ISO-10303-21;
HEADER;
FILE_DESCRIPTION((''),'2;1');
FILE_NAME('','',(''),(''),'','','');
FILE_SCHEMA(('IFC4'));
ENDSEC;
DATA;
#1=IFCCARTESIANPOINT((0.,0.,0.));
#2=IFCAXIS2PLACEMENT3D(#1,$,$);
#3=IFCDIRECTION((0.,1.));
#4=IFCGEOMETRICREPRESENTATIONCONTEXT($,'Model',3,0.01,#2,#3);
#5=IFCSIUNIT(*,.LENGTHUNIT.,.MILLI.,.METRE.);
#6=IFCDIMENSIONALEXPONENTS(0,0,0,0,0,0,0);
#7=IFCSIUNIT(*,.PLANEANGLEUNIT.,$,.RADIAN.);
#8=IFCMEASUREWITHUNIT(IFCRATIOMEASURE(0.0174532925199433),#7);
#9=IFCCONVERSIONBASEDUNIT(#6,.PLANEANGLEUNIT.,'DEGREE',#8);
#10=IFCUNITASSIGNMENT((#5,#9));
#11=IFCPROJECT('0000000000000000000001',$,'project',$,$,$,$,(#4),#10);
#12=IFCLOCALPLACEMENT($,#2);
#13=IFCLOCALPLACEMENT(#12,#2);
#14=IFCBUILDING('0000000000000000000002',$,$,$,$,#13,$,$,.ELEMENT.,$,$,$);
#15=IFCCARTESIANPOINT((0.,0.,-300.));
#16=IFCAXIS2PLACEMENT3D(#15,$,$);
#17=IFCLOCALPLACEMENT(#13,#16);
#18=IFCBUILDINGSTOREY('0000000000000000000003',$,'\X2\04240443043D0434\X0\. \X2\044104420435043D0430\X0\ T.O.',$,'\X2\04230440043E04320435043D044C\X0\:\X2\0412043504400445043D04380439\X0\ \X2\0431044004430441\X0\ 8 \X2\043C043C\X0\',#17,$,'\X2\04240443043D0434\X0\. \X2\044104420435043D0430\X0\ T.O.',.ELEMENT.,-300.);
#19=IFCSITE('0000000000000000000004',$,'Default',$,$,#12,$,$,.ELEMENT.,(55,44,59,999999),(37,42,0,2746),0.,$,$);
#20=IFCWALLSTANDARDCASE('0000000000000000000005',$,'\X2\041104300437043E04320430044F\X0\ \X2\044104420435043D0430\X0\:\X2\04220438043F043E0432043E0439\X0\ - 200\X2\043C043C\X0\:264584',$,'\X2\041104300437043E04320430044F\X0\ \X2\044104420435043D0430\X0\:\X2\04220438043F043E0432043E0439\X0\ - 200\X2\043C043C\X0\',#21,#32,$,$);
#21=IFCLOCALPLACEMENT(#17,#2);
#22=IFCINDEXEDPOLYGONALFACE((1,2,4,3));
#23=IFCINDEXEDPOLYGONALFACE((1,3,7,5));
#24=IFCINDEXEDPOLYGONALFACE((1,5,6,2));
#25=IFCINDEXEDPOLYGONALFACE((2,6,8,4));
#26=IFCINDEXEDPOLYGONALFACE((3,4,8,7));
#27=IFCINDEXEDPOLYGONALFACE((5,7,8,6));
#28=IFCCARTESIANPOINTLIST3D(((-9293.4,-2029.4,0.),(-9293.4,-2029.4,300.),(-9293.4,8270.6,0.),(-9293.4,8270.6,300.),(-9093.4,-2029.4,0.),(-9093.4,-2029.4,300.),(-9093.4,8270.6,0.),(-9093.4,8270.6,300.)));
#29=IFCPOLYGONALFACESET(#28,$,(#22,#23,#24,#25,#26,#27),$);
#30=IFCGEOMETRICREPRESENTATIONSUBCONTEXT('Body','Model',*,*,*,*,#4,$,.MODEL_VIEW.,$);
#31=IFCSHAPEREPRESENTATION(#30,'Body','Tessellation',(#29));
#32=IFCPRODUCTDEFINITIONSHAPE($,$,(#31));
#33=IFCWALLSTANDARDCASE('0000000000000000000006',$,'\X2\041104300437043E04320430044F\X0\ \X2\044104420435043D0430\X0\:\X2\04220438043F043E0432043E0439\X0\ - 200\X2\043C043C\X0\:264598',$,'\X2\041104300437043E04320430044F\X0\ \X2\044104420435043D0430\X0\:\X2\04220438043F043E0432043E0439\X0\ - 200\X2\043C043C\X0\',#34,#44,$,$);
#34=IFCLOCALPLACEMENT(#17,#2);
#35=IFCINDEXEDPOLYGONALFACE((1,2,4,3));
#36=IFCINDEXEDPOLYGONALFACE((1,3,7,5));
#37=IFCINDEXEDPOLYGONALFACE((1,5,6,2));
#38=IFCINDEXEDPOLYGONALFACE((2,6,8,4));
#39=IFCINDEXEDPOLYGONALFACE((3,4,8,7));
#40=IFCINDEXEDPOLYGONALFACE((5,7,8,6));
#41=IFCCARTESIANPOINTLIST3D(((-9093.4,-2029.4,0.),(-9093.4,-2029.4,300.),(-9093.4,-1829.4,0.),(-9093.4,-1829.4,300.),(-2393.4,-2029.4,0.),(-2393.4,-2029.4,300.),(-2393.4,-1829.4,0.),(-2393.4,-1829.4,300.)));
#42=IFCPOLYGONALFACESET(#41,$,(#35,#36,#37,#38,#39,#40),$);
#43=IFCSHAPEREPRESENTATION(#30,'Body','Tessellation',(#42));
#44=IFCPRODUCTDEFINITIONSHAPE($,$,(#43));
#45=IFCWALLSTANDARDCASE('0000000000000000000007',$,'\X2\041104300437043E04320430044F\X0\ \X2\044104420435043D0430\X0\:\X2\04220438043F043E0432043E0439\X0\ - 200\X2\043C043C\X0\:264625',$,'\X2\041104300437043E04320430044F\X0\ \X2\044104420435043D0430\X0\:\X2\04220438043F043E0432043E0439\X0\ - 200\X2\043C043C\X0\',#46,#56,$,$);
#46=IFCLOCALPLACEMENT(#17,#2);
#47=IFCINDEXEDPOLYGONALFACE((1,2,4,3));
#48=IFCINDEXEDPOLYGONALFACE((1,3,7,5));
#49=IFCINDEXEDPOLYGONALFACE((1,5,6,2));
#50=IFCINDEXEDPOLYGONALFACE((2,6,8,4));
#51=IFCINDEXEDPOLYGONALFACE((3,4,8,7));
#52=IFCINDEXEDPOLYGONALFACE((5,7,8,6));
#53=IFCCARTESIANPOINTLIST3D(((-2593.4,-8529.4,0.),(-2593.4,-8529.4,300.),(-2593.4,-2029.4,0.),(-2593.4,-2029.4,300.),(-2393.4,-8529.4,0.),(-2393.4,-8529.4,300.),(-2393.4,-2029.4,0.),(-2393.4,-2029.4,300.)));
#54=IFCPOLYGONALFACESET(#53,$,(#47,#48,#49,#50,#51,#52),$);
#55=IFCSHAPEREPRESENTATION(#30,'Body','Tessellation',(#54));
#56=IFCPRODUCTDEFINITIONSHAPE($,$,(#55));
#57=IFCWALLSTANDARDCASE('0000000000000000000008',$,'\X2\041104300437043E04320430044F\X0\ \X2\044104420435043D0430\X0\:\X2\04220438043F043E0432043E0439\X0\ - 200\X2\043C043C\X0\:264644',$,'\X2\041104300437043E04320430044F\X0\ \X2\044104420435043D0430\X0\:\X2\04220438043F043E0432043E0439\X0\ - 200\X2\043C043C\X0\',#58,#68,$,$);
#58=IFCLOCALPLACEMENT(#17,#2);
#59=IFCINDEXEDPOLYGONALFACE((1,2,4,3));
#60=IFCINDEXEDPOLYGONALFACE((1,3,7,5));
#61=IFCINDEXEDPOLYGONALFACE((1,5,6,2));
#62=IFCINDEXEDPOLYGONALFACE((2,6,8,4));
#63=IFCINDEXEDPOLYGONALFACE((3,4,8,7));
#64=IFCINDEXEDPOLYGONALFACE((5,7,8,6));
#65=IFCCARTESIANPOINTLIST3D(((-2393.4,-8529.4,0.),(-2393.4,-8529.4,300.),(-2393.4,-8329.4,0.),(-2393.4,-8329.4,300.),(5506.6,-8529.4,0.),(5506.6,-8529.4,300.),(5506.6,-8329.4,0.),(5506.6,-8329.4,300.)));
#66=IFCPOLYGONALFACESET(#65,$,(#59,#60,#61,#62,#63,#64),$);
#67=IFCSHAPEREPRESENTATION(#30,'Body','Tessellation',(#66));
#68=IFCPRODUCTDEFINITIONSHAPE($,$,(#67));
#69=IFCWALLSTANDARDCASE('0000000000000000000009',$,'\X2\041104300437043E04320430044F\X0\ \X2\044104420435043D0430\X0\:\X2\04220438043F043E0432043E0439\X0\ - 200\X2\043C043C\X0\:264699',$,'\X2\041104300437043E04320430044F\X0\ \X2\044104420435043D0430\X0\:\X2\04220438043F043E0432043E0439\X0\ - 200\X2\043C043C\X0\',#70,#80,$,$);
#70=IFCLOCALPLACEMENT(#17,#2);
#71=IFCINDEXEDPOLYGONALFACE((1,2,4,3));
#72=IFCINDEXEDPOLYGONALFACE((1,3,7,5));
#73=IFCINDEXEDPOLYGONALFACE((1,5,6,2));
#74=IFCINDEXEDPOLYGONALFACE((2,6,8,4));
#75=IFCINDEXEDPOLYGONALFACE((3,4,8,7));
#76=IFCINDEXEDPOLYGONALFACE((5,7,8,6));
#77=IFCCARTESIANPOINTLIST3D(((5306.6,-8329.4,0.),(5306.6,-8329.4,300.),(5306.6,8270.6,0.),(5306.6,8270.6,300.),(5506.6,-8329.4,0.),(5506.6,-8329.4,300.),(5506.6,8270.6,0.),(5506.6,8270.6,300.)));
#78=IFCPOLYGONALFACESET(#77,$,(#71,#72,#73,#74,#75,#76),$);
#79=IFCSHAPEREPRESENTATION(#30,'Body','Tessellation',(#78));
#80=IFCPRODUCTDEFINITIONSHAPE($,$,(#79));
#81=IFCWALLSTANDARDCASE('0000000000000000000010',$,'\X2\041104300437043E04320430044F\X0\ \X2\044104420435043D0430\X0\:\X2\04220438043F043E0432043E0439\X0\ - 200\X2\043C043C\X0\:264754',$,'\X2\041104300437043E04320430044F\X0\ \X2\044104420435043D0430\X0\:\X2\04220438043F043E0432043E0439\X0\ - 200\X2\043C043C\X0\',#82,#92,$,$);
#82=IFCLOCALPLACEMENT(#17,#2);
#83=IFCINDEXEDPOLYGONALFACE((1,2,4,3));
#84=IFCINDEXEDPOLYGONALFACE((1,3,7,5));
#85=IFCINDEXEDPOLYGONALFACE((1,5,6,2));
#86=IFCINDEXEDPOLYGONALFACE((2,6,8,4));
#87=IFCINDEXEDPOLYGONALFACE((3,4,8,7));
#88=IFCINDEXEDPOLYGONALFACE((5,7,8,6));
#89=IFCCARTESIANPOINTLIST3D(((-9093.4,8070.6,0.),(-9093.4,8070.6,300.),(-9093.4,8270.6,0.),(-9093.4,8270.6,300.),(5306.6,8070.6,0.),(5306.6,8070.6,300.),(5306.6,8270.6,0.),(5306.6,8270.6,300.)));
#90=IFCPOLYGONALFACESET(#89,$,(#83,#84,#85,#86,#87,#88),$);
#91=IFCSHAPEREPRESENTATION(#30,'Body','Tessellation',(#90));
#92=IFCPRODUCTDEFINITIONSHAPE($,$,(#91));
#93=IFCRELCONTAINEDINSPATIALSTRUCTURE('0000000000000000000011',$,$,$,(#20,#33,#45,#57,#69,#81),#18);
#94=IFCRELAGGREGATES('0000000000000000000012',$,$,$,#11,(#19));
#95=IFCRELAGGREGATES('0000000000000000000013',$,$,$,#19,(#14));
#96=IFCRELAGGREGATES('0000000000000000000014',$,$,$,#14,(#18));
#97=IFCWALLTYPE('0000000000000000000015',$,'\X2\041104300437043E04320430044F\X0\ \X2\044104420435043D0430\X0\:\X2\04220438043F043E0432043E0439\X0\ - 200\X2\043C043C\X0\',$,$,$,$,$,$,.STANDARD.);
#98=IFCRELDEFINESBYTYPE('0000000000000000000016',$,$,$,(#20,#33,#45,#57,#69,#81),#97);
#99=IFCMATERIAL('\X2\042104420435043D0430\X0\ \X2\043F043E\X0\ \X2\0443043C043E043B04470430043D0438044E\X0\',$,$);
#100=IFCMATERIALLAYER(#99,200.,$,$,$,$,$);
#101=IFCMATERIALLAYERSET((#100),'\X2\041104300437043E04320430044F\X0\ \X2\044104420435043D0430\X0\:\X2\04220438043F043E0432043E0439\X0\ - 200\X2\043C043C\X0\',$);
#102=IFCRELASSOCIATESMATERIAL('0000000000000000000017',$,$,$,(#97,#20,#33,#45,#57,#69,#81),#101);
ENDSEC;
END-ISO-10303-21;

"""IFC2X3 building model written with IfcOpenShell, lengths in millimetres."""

from ifc_helpers import new_model, entity, si_unit, converted_unit, direction, frame, frame_2d, origin, place, context, subcontext, project, spatial, rectangle, extrude, clip, halfspace, material, layer, layer_set, layer_usage, type_object, element, save


model = new_model("IFC2X3")

# Units and contexts
model_context = context("Model", 3, precision=0.01, world=origin(), true_north=direction((0.0, 1.0)))
body_context = subcontext(model_context, "Body", "Model", "MODEL_VIEW")
ifc_project = project(units=[si_unit("LENGTHUNIT", "METRE", prefix="MILLI"), converted_unit("PLANEANGLEUNIT", "DEGREE", entity("IfcRatioMeasure", 0.0174532925199433), si_unit("PLANEANGLEUNIT", "RADIAN"), dimensions=[0, 0, 0, 0, 0, 0, 0])], contexts=[model_context])

# Site, building, storey
site_placement = place(None, origin())
site = spatial("IfcSite", under=ifc_project, at=site_placement, Name="Default", CompositionType="ELEMENT", RefLatitude=(55, 44, 59, 999999), RefLongitude=(37, 42, 0, 2746), RefElevation=0.0)
building_placement = place(site_placement, origin())
building = spatial("IfcBuilding", under=site, at=building_placement, CompositionType="ELEMENT")
storey_placement = place(building_placement, frame((0.0, 0.0, -300.0)))
storey = spatial("IfcBuildingStorey", under=building, at=storey_placement, Name="Фунд. стена T.O.", ObjectType="Уровень:Верхний брус 8 мм", LongName="Фунд. стена T.O.", CompositionType="ELEMENT", Elevation=-300.0)

# Walls
ifc_material = material(Name="Стена по умолчанию")
ifc_layer = layer(ifc_material, 200.0)
ifc_layer_set = layer_set([ifc_layer], Name="Базовая стена:Типовой - 200мм")
ifc_layer_usage_1 = layer_usage(ifc_layer_set, "AXIS2", "NEGATIVE", 100.0)
wall_type = type_object("IfcWallType", Name="Базовая стена:Типовой - 200мм", PredefinedType="STANDARD", material=ifc_layer_set)
wall_1_placement = place(storey_placement, frame((-9193.4, 8270.6, 0.0), z_axis=(0.0, 0.0, 1.0), x_axis=(0.0, -1.0, 0.0)))
element("IfcWallStandardCase", 1, at=wall_1_placement, inside=storey, type_object=wall_type, material=ifc_layer_usage_1, Name="Базовая стена:Типовой - 200мм:264584", ObjectType="Базовая стена:Типовой - 200мм", context=body_context, shape_type="Clipping", body=[
    clip(extrude(rectangle(XDim=10300.0, YDim=200.0, at=frame_2d((5150.0, 0.0), x_axis=(-1.0, 0.0))), origin(), (0.0, 0.0, 1.0), 300.0), halfspace(frame((0.0, 0.0, -4300.0)), True)),
])
ifc_layer_usage_2 = layer_usage(ifc_layer_set, "AXIS2", "NEGATIVE", 100.0)
wall_2_placement = place(storey_placement, frame((-9093.4, -1929.4, 0.0)))
element("IfcWallStandardCase", 2, at=wall_2_placement, inside=storey, type_object=wall_type, material=ifc_layer_usage_2, Name="Базовая стена:Типовой - 200мм:264598", ObjectType="Базовая стена:Типовой - 200мм", context=body_context, shape_type="Clipping", body=[
    clip(extrude(rectangle(XDim=6700.0, YDim=200.0, at=frame_2d((3350.0, 0.0), x_axis=(-1.0, 0.0))), origin(), (0.0, 0.0, 1.0), 300.0), halfspace(frame((0.0, 0.0, -4300.0)), True)),
])
ifc_layer_usage_3 = layer_usage(ifc_layer_set, "AXIS2", "NEGATIVE", 100.0)
wall_3_placement = place(storey_placement, frame((-2493.4, -2029.4, 0.0), z_axis=(0.0, 0.0, 1.0), x_axis=(0.0, -1.0, 0.0)))
element("IfcWallStandardCase", 3, at=wall_3_placement, inside=storey, type_object=wall_type, material=ifc_layer_usage_3, Name="Базовая стена:Типовой - 200мм:264625", ObjectType="Базовая стена:Типовой - 200мм", context=body_context, shape_type="Clipping", body=[
    clip(extrude(rectangle(XDim=6500.0, YDim=200.0, at=frame_2d((3250.0, 0.0), x_axis=(-1.0, 0.0))), origin(), (0.0, 0.0, 1.0), 300.0), halfspace(frame((0.0, 0.0, -4300.0)), True)),
])
ifc_layer_usage_4 = layer_usage(ifc_layer_set, "AXIS2", "NEGATIVE", 100.0)
wall_4_placement = place(storey_placement, frame((-2393.4, -8429.4, 0.0)))
element("IfcWallStandardCase", 4, at=wall_4_placement, inside=storey, type_object=wall_type, material=ifc_layer_usage_4, Name="Базовая стена:Типовой - 200мм:264644", ObjectType="Базовая стена:Типовой - 200мм", context=body_context, shape_type="Clipping", body=[
    clip(extrude(rectangle(XDim=7900.0, YDim=200.0, at=frame_2d((3950.0, 0.0), x_axis=(-1.0, 0.0))), origin(), (0.0, 0.0, 1.0), 300.0), halfspace(frame((0.0, 0.0, -4300.0)), True)),
])
ifc_layer_usage_5 = layer_usage(ifc_layer_set, "AXIS2", "NEGATIVE", 100.0)
wall_5_placement = place(storey_placement, frame((5406.6, -8329.4, 0.0), z_axis=(0.0, 0.0, 1.0), x_axis=(0.0, 1.0, 0.0)))
element("IfcWallStandardCase", 5, at=wall_5_placement, inside=storey, type_object=wall_type, material=ifc_layer_usage_5, Name="Базовая стена:Типовой - 200мм:264699", ObjectType="Базовая стена:Типовой - 200мм", context=body_context, shape_type="Clipping", body=[
    clip(extrude(rectangle(XDim=16600.0, YDim=200.0, at=frame_2d((8300.0, 0.0), x_axis=(-1.0, 0.0))), origin(), (0.0, 0.0, 1.0), 300.0), halfspace(frame((0.0, 0.0, -4300.0)), True)),
])
ifc_layer_usage_6 = layer_usage(ifc_layer_set, "AXIS2", "NEGATIVE", 100.0)
wall_6_placement = place(storey_placement, frame((5306.6, 8170.6, 0.0), z_axis=(0.0, 0.0, 1.0), x_axis=(-1.0, 0.0, 0.0)))
element("IfcWallStandardCase", 6, at=wall_6_placement, inside=storey, type_object=wall_type, material=ifc_layer_usage_6, Name="Базовая стена:Типовой - 200мм:264754", ObjectType="Базовая стена:Типовой - 200мм", context=body_context, shape_type="Clipping", body=[
    clip(extrude(rectangle(XDim=14400.0, YDim=200.0, at=frame_2d((7200.0, 0.0), x_axis=(-1.0, 0.0))), origin(), (0.0, 0.0, 1.0), 300.0), halfspace(frame((0.0, 0.0, -4300.0)), True)),
])

save(model, "model.ifc")
